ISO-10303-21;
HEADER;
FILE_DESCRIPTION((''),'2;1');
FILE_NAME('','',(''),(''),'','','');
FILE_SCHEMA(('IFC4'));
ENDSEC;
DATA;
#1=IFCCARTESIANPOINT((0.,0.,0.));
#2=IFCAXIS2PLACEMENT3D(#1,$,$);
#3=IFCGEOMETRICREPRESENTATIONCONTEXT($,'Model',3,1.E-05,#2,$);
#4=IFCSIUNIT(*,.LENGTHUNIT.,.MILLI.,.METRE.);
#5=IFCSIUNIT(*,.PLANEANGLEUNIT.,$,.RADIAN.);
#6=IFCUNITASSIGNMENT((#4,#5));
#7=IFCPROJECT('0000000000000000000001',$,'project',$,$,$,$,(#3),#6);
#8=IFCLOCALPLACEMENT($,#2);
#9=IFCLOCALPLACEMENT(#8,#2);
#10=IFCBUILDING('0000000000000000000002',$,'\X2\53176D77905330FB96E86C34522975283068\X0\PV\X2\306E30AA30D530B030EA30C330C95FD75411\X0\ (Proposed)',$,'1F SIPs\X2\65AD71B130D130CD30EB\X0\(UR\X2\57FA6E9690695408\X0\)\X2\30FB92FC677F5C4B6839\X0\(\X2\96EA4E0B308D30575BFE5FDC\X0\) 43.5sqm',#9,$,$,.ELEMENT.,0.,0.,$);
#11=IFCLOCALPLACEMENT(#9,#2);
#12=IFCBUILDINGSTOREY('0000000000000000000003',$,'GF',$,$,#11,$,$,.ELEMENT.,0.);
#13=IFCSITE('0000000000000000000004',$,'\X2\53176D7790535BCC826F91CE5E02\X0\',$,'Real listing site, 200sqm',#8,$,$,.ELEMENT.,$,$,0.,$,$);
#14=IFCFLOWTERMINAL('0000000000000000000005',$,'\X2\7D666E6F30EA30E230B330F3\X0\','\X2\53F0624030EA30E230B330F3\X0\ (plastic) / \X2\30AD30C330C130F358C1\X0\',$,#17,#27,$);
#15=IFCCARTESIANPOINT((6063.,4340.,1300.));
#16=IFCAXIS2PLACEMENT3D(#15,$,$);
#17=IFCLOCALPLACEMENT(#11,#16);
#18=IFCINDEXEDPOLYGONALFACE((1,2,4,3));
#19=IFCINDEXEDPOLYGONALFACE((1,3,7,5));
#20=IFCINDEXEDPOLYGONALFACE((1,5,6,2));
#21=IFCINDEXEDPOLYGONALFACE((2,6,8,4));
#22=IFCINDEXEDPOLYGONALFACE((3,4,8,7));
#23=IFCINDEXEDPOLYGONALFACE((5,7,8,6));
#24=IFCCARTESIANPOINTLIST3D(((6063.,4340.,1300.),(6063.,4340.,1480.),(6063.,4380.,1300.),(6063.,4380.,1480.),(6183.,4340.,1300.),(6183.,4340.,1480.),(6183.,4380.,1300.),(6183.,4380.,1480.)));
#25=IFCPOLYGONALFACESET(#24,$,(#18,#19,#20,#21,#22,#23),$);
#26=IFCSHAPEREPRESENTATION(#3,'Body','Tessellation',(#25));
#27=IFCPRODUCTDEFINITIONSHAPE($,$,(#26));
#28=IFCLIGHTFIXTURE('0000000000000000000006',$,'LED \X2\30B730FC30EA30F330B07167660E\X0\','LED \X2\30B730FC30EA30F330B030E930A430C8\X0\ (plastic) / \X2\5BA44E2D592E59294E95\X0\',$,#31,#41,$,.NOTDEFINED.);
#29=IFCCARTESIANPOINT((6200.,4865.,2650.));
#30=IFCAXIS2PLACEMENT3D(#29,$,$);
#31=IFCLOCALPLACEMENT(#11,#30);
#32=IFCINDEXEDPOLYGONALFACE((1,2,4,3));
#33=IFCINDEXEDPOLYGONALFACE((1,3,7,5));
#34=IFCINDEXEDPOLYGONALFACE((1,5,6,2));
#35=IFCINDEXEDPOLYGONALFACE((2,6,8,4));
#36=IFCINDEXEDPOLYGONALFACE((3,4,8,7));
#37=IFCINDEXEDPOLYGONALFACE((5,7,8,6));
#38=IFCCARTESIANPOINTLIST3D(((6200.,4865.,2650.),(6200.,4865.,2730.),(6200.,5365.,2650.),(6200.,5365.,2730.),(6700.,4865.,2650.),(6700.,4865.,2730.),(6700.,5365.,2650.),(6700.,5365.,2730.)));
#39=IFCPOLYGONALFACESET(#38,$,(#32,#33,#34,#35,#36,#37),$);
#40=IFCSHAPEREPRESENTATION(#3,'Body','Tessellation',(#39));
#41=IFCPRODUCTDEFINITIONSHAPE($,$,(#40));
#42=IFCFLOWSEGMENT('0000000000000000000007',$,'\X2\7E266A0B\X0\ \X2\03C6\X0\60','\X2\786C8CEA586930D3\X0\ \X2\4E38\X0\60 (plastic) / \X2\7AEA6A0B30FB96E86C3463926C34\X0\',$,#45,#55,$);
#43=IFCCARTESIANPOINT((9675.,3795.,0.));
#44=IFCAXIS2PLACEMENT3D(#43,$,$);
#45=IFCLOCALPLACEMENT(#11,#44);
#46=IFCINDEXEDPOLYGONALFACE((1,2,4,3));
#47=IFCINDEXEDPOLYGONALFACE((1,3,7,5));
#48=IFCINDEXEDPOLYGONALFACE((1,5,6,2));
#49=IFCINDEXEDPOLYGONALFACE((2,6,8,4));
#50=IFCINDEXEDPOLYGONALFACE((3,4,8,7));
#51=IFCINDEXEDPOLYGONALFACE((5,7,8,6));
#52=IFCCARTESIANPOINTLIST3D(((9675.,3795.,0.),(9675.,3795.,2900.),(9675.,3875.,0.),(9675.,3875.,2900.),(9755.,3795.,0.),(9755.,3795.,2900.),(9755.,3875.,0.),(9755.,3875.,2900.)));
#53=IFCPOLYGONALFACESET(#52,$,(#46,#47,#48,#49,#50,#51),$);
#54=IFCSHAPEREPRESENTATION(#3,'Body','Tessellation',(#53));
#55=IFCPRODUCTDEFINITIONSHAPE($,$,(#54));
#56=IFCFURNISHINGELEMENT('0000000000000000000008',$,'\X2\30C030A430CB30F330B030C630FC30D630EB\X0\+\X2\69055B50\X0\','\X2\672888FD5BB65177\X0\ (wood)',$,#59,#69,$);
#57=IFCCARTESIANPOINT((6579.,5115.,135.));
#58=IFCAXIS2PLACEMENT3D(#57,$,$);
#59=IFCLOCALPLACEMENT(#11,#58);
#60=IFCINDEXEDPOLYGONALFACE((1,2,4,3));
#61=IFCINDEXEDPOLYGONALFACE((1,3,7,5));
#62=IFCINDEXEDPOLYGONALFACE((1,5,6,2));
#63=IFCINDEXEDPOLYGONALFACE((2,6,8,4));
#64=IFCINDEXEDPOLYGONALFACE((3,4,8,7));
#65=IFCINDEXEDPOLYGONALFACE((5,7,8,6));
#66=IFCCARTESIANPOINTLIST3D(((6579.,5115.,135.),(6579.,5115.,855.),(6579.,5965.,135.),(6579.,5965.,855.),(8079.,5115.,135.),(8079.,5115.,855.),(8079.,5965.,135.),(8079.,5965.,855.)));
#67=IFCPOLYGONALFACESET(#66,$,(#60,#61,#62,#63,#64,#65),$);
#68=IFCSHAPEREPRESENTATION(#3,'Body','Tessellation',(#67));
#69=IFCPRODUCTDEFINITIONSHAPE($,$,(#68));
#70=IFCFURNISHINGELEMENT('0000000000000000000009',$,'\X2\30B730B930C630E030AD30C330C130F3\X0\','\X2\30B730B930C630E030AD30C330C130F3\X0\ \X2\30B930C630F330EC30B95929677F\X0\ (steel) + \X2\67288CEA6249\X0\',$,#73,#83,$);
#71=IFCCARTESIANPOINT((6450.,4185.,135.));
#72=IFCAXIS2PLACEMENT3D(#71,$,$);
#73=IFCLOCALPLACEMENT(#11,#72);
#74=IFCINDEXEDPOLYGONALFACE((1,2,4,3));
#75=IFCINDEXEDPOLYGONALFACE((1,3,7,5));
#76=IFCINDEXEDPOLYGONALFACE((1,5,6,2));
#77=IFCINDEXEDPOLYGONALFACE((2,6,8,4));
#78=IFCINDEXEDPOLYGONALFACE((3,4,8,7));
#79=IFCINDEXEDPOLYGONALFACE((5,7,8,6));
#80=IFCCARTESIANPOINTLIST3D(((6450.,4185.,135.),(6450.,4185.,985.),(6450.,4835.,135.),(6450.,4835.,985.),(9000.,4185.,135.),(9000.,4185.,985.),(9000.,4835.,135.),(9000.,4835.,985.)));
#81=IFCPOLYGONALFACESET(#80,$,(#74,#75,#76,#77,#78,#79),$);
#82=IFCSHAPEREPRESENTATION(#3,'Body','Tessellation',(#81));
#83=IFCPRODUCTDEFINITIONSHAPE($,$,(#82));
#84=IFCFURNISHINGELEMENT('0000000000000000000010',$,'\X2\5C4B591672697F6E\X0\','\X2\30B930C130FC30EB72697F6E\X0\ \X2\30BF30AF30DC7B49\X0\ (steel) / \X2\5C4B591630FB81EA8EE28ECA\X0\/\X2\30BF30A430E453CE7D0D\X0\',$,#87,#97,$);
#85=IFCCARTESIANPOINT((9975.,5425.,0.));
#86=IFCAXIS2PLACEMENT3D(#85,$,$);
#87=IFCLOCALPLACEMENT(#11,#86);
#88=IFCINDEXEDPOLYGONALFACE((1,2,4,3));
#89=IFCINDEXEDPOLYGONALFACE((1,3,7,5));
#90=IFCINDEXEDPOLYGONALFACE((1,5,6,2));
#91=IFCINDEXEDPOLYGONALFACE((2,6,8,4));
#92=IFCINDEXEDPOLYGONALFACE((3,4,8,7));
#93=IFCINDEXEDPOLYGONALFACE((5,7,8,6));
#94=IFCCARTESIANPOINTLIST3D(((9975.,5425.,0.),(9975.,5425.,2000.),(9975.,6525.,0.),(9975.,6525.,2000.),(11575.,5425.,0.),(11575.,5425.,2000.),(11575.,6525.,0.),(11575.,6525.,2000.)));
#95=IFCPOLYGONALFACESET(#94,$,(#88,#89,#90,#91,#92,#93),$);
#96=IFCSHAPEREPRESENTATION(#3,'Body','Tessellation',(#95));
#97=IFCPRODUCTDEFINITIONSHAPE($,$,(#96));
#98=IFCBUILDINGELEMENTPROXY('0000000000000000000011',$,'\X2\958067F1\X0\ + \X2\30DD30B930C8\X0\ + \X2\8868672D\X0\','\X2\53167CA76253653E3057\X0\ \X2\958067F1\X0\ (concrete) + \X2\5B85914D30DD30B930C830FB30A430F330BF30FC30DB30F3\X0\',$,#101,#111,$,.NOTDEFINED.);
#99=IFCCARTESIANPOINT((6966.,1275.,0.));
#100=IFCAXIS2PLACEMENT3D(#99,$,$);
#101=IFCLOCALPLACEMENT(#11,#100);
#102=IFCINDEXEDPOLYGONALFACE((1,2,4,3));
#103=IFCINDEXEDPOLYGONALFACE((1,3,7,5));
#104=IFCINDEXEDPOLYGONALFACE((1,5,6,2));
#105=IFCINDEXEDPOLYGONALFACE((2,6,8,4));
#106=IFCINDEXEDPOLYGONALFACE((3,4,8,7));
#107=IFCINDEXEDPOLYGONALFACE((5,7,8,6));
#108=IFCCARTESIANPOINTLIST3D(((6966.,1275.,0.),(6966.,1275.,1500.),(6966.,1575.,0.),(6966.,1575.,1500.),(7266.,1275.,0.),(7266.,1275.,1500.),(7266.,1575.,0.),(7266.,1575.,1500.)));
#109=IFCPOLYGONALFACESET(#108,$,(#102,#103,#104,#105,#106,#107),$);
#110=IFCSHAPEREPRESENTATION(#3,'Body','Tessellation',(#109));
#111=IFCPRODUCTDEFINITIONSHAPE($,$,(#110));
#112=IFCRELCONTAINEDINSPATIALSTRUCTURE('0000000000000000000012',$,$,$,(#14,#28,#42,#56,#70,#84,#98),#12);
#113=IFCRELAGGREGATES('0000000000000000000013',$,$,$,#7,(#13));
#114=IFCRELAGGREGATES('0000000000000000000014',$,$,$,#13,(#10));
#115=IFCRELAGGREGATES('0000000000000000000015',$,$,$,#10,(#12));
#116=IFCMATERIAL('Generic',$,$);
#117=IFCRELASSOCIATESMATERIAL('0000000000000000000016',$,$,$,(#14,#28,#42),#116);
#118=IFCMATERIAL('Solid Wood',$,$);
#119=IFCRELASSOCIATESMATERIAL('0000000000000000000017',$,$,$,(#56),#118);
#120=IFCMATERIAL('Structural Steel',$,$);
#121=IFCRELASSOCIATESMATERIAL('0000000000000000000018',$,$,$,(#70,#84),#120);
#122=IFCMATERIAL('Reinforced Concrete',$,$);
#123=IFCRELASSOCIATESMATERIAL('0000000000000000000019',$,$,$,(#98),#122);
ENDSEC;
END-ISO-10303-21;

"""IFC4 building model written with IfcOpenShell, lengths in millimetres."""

from ifc_helpers import new_model, si_unit, frame, frame_2d, origin, place, context, project, spatial, rectangle, extrude, material, element, save


model = new_model("IFC4")

# Units and contexts
model_context = context("Model", 3, precision=1e-05, world=origin())
ifc_project = project(units=[si_unit("LENGTHUNIT", "METRE", prefix="MILLI"), si_unit("PLANEANGLEUNIT", "RADIAN")], contexts=[model_context])

# Site, building, storey
site_placement = place(None, origin())
site = spatial("IfcSite", under=ifc_project, at=site_placement, Name="北海道富良野市", ObjectType="Real listing site, 200sqm", CompositionType="ELEMENT", RefElevation=0.0)
building_placement = place(site_placement, origin())
building = spatial("IfcBuilding", under=site, at=building_placement, Name="北海道・雨水利用とPVのオフグリッド志向 (Proposed)", ObjectType="1F SIPs断熱パネル(UR基準適合)・鋼板屋根(雪下ろし対応) 43.5sqm", CompositionType="ELEMENT", ElevationOfRefHeight=0.0, ElevationOfTerrain=0.0)
storey_placement = place(building_placement, origin())
storey = spatial("IfcBuildingStorey", under=building, at=storey_placement, Name="GF", CompositionType="ELEMENT", Elevation=0.0)

# Shared definitions
ifc_material_1 = material(Name="Solid Wood")

# Shared definitions
ifc_material_2 = material(Name="Structural Steel")

# Shared definitions
ifc_material_3 = material(Name="Reinforced Concrete")

# Flow terminal
ifc_material_4 = material(Name="Generic")
flow_terminal_1_placement = place(storey_placement, frame((6063.0, 4340.0, 1300.0)))
element("IfcFlowTerminal", 1, at=flow_terminal_1_placement, inside=storey, material=ifc_material_4, Name="給湯リモコン", Description="台所リモコン (plastic) / キッチン壁", context=model_context, shape_type="SweptSolid", body=[
    extrude(rectangle(XDim=120.0, YDim=40.0, at=frame_2d((60.0, 20.0))), frame((6063.0, 4340.0, 1300.0)), (0.0, 0.0, 1.0), 180.0),
])

# Light fixture
light_fixture_placement = place(storey_placement, frame((6200.0, 4865.0, 2650.0)))
element("IfcLightFixture", 2, at=light_fixture_placement, inside=storey, material=ifc_material_4, Name="LED シーリング照明", Description="LED シーリングライト (plastic) / 室中央天井", PredefinedType="NOTDEFINED", context=model_context, shape_type="SweptSolid", body=[
    extrude(rectangle(XDim=500.0, YDim=500.0, at=frame_2d((250.0, 250.0))), frame((6200.0, 4865.0, 2650.0)), (0.0, 0.0, 1.0), 80.0),
])

# Flow segment
flow_segment_placement = place(storey_placement, frame((9675.0, 3795.0, 0.0)))
element("IfcFlowSegment", 3, at=flow_segment_placement, inside=storey, material=ifc_material_4, Name="縦樋 φ60", Description="硬質塩ビ 丸60 (plastic) / 竪樋・雨水排水", context=model_context, shape_type="SweptSolid", body=[
    extrude(rectangle(XDim=80.0, YDim=80.0, at=frame_2d((40.0, 40.0))), frame((9675.0, 3795.0, 0.0)), (0.0, 0.0, 1.0), 2900.0),
])

# Furnishing elements
furnishing_1_placement = place(storey_placement, frame((6579.0, 5115.0, 135.0)))
element("IfcFurnishingElement", 4, at=furnishing_1_placement, inside=storey, material=ifc_material_1, Name="ダイニングテーブル+椅子", Description="木製家具 (wood)", context=model_context, shape_type="SweptSolid", body=[
    extrude(rectangle(XDim=1500.0, YDim=850.0, at=frame_2d((750.0, 425.0))), frame((6579.0, 5115.0, 135.0)), (0.0, 0.0, 1.0), 720.0),
])
furnishing_2_placement = place(storey_placement, frame((6450.0, 4185.0, 135.0)))
element("IfcFurnishingElement", 5, at=furnishing_2_placement, inside=storey, material=ifc_material_2, Name="システムキッチン", Description="システムキッチン ステンレス天板 (steel) + 木質扉", context=model_context, shape_type="SweptSolid", body=[
    extrude(rectangle(XDim=2550.0, YDim=650.0, at=frame_2d((1275.0, 325.0))), frame((6450.0, 4185.0, 135.0)), (0.0, 0.0, 1.0), 850.0),
])
furnishing_3_placement = place(storey_placement, frame((9975.0, 5425.0, 0.0)))
element("IfcFurnishingElement", 6, at=furnishing_3_placement, inside=storey, material=ifc_material_2, Name="屋外物置", Description="スチール物置 タクボ等 (steel) / 屋外・自転車/タイヤ収納", context=model_context, shape_type="SweptSolid", body=[
    extrude(rectangle(XDim=1600.0, YDim=1100.0, at=frame_2d((800.0, 550.0))), frame((9975.0, 5425.0, 0.0)), (0.0, 0.0, 1.0), 2000.0),
])

# Building element proxy
proxy_placement = place(storey_placement, frame((6966.0, 1275.0, 0.0)))
element("IfcBuildingElementProxy", 7, at=proxy_placement, inside=storey, material=ifc_material_3, Name="門柱 + ポスト + 表札", Description="化粧打放し 門柱 (concrete) + 宅配ポスト・インターホン", PredefinedType="NOTDEFINED", context=model_context, shape_type="SweptSolid", body=[
    extrude(rectangle(XDim=300.0, YDim=300.0, at=frame_2d((150.0, 150.0))), frame((6966.0, 1275.0, 0.0)), (0.0, 0.0, 1.0), 1500.0),
])

save(model, "model.ifc")
